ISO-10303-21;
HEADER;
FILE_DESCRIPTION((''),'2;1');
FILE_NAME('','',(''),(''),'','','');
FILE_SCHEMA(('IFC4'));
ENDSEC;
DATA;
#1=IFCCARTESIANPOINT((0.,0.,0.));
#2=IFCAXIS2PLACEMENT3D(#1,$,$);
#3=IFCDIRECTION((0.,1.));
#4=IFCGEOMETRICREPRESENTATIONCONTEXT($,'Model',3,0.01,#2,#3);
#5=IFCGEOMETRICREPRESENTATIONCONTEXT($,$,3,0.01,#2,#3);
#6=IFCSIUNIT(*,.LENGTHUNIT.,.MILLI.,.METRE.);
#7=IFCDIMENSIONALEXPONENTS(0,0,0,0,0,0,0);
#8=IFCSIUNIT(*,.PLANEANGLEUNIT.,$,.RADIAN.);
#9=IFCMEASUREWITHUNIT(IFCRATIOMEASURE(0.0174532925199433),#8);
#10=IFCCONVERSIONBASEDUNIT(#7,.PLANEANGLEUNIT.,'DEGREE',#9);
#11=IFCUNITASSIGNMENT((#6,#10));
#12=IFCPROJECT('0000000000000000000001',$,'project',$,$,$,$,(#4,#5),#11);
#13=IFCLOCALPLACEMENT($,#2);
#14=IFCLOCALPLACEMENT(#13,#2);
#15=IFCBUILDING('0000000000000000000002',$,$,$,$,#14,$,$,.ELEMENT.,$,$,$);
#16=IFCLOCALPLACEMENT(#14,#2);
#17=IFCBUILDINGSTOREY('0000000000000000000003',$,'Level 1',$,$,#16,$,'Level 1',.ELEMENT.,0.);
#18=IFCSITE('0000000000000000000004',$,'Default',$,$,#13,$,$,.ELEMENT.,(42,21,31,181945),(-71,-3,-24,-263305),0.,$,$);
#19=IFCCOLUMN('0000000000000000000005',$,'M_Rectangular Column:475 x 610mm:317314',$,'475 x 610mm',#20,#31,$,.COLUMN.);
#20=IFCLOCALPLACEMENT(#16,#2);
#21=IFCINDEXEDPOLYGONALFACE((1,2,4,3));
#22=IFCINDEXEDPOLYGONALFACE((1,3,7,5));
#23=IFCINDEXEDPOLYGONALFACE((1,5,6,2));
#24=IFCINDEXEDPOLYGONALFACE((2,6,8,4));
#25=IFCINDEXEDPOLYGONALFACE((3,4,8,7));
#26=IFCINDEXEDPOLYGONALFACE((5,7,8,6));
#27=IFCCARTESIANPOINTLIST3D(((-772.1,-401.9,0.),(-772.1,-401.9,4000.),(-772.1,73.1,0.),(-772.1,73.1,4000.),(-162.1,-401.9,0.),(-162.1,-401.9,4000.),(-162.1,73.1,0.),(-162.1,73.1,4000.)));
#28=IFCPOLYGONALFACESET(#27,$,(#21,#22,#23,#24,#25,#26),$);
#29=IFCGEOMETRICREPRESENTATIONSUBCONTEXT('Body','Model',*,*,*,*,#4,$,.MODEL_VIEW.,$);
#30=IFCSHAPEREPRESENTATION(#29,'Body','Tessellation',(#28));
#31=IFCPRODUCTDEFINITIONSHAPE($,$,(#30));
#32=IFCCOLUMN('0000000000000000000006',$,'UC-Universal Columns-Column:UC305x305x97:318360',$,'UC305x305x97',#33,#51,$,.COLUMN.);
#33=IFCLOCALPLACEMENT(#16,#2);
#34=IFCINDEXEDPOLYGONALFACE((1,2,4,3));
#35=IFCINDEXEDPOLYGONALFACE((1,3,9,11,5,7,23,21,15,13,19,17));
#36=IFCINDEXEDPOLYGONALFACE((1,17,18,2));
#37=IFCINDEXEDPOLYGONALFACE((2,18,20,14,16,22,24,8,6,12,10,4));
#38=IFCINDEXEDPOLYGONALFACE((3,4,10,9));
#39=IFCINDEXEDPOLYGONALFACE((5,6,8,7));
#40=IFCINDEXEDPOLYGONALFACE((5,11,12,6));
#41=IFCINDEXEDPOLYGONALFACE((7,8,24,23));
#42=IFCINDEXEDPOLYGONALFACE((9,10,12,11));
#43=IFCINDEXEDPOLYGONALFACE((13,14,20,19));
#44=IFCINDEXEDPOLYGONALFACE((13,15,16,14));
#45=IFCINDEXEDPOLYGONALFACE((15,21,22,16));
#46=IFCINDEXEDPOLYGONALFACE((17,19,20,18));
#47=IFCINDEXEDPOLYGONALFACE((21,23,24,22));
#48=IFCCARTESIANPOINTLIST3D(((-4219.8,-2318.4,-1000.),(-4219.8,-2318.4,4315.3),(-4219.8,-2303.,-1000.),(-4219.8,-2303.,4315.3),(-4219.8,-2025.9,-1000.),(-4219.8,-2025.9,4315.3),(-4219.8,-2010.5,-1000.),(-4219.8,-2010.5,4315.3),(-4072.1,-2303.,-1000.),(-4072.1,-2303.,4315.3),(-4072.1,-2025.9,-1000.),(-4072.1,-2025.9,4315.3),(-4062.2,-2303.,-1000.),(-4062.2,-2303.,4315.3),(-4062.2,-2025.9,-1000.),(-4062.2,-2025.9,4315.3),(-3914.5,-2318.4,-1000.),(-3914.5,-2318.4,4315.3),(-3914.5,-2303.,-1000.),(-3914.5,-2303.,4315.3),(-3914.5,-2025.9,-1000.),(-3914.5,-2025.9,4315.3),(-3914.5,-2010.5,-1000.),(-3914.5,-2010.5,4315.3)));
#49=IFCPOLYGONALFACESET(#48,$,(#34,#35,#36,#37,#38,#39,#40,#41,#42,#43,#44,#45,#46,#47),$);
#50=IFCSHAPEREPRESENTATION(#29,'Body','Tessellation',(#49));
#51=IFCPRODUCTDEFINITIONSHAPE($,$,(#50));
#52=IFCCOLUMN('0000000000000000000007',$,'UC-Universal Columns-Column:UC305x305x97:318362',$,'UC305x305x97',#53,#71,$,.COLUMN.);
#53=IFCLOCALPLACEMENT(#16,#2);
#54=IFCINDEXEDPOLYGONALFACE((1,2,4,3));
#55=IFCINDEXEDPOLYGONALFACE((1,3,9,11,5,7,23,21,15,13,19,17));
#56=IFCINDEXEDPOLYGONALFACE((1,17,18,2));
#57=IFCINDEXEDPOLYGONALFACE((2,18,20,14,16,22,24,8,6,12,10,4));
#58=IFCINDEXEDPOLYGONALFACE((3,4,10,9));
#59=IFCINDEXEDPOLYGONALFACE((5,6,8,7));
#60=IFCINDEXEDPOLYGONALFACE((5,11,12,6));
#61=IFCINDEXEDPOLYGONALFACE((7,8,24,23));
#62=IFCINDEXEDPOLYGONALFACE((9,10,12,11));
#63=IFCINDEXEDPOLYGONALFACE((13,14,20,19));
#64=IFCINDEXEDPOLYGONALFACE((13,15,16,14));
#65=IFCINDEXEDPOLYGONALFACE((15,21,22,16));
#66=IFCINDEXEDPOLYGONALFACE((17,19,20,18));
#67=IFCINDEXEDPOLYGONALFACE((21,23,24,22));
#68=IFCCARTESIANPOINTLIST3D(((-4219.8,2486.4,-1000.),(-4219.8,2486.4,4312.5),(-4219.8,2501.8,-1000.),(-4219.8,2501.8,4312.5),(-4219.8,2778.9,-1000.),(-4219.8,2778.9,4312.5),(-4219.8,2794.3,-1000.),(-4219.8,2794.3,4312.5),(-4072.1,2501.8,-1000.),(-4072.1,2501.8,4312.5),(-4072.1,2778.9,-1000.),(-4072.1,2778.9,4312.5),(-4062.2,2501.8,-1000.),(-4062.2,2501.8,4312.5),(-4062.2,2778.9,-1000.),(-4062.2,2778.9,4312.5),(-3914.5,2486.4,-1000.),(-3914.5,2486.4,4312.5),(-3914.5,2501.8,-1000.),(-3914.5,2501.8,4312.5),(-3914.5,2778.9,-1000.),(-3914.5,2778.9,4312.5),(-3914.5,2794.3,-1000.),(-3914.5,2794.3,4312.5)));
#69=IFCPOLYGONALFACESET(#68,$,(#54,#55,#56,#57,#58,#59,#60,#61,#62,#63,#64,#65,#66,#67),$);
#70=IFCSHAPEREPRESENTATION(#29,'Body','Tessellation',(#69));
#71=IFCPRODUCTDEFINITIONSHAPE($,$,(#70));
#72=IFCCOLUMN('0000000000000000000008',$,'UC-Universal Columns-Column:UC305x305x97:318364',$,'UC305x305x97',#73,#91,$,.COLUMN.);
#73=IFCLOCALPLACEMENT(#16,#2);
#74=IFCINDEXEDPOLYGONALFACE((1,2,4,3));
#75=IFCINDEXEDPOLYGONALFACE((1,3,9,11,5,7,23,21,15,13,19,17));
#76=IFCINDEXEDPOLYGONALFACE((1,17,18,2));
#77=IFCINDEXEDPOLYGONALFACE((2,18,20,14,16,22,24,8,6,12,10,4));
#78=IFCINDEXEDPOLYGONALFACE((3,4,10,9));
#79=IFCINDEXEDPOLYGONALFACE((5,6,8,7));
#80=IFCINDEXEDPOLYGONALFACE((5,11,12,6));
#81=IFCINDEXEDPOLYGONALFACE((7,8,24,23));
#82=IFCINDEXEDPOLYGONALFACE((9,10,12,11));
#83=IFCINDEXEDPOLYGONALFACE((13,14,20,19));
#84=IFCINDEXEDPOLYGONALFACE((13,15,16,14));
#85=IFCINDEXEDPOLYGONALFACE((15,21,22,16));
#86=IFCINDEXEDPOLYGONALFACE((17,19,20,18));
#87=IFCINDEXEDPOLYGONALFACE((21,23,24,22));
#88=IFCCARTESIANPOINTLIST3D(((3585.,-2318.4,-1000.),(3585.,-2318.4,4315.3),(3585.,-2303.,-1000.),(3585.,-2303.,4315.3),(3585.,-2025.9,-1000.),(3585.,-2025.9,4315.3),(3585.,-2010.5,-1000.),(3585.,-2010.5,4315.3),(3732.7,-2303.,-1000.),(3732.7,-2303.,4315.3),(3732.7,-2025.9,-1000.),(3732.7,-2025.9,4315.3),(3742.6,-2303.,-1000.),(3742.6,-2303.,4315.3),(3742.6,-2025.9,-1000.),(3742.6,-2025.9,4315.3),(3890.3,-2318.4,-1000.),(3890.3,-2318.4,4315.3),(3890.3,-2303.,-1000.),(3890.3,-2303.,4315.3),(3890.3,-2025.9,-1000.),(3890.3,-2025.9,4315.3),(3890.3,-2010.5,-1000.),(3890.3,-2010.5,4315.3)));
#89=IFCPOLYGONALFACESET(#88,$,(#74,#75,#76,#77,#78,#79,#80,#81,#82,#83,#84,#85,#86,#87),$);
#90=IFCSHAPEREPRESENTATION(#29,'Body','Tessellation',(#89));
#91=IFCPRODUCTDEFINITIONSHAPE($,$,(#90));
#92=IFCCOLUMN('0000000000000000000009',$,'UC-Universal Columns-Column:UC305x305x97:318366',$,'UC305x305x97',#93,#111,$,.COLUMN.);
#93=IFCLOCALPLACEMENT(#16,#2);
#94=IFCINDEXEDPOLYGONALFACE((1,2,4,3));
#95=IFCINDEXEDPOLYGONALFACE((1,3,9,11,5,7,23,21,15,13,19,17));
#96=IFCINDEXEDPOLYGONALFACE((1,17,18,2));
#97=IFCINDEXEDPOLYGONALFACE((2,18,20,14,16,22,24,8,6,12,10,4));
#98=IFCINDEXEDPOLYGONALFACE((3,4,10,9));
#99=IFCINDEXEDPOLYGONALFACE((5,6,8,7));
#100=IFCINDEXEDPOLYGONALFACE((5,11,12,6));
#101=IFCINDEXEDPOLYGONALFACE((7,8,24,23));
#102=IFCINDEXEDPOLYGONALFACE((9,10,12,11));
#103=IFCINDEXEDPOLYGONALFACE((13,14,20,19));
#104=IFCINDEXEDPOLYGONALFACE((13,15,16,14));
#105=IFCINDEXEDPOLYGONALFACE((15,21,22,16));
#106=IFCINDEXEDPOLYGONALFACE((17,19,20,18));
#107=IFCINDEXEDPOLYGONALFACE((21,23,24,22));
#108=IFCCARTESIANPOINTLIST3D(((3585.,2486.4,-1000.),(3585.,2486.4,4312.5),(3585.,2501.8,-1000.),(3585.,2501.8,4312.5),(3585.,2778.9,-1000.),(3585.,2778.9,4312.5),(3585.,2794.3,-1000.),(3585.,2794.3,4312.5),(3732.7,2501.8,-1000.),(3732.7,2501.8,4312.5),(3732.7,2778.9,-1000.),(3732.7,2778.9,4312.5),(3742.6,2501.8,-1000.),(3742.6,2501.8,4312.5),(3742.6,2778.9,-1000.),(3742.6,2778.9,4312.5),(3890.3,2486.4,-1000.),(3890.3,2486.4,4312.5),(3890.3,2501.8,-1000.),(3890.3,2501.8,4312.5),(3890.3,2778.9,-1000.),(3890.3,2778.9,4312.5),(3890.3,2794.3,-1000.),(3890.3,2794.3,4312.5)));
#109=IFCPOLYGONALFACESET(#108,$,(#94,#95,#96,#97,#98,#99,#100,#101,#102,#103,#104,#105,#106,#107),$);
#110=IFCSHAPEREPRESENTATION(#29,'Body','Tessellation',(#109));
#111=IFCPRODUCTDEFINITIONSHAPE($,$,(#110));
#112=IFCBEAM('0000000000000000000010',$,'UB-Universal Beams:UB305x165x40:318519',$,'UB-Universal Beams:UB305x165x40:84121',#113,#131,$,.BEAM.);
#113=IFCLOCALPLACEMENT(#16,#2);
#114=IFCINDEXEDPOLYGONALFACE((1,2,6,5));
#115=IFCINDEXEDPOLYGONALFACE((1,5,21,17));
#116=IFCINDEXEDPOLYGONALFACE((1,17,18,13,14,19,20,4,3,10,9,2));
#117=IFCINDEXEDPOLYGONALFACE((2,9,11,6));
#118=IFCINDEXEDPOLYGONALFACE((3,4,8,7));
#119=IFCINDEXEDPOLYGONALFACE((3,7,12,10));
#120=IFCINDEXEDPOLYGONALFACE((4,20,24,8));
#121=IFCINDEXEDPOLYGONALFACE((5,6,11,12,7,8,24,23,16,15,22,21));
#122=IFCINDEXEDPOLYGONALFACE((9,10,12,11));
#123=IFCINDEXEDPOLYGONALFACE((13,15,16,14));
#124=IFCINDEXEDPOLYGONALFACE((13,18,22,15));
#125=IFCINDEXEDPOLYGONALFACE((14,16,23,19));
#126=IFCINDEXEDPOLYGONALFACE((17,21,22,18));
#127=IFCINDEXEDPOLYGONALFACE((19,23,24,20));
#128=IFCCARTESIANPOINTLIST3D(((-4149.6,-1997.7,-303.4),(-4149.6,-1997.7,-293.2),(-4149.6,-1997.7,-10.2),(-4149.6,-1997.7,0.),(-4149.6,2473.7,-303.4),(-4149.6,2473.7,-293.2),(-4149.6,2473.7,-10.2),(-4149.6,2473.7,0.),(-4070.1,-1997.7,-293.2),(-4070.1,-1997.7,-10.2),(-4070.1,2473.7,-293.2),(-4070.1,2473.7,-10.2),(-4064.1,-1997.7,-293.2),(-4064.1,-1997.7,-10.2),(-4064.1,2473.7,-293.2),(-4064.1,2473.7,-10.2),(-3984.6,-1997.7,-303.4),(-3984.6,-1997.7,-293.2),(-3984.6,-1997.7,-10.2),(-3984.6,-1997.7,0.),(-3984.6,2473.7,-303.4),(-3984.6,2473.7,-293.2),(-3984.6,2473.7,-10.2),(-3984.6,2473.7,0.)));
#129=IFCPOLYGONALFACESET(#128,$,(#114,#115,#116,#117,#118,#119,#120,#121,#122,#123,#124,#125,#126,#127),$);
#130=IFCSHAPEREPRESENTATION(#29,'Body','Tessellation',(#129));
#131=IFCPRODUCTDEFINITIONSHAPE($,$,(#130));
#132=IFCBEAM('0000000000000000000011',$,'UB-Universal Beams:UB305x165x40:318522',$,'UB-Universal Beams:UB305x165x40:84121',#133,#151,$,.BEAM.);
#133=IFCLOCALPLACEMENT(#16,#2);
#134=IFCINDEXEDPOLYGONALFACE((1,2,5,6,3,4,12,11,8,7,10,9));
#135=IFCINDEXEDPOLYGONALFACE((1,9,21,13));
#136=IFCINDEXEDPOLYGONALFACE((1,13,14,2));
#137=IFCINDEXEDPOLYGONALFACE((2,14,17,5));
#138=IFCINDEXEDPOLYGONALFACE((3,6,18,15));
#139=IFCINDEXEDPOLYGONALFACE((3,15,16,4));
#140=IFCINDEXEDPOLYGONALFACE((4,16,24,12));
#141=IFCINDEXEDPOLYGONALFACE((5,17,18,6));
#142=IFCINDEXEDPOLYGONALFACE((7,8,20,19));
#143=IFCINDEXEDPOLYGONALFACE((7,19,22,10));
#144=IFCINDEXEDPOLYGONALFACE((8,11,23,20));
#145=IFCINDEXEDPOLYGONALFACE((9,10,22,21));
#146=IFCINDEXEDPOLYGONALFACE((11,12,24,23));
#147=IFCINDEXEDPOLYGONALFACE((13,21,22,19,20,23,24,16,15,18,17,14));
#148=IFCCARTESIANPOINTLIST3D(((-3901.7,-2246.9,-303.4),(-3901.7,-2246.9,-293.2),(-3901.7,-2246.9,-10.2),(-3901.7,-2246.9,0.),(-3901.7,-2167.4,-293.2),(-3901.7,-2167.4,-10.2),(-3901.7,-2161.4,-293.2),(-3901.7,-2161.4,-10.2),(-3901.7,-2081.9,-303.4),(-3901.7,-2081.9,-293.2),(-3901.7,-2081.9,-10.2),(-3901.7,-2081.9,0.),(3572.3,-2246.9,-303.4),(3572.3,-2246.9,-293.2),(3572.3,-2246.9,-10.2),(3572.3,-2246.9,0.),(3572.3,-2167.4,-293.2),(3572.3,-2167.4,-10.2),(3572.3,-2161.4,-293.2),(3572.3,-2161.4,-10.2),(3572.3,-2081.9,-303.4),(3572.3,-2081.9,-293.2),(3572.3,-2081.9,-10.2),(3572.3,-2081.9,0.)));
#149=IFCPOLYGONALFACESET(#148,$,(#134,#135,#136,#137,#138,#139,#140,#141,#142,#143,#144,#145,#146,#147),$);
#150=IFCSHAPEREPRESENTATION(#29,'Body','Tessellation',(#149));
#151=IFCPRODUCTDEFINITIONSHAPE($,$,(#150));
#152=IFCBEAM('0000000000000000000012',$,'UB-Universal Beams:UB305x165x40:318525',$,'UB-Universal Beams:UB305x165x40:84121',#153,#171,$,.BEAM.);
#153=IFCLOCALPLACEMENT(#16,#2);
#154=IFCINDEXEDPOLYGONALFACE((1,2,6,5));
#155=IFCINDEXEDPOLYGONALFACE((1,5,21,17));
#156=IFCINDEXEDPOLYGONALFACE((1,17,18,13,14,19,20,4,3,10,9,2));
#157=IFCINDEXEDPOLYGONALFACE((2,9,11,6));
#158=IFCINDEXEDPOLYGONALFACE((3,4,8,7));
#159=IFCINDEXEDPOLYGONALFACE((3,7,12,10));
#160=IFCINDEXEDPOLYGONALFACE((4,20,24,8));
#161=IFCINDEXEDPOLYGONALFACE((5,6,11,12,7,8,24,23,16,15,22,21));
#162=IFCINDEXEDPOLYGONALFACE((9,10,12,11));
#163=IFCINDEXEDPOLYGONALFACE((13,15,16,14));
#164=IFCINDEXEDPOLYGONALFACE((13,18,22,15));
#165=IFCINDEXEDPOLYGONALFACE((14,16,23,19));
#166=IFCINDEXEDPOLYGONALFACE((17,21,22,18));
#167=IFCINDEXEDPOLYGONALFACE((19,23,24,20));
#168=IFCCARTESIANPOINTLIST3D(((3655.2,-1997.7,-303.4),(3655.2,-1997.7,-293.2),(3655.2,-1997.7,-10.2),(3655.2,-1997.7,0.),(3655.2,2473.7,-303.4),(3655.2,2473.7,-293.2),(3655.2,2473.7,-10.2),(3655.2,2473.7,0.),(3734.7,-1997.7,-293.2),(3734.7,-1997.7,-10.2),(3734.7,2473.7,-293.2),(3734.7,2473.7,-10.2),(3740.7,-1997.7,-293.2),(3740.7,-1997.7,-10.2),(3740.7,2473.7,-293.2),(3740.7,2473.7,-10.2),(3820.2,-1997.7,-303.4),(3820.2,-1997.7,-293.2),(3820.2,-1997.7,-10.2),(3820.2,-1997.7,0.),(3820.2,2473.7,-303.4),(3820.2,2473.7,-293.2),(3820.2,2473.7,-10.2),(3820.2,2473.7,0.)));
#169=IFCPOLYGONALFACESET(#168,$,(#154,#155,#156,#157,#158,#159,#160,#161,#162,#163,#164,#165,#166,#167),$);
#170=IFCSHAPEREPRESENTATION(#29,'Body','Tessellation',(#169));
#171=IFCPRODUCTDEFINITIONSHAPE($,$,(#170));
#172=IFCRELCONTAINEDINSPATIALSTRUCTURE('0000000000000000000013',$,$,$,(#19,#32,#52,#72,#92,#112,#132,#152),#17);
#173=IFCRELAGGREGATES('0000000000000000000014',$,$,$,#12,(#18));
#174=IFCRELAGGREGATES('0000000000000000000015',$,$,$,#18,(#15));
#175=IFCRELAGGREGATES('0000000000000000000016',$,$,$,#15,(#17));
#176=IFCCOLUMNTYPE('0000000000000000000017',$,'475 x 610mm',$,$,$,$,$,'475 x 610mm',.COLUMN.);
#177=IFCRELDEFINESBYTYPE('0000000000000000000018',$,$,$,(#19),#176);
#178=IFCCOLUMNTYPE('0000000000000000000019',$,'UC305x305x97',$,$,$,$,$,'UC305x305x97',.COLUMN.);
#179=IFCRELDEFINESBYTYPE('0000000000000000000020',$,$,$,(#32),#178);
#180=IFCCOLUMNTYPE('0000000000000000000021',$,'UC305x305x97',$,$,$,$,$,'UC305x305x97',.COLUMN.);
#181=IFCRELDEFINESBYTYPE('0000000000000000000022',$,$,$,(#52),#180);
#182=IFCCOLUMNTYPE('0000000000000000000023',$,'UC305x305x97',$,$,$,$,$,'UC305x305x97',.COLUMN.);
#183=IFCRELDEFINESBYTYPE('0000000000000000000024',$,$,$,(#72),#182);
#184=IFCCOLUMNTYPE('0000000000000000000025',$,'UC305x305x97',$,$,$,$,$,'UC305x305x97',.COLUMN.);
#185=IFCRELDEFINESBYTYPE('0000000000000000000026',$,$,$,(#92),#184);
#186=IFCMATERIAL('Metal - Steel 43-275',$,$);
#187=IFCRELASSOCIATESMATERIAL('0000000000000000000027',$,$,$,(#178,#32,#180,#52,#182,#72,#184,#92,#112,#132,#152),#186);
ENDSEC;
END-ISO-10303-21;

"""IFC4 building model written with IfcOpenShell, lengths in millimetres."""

from ifc_helpers import new_model, entity, si_unit, converted_unit, direction, frame, frame_2d, origin, origin_2d_with_axis, place, context, subcontext, project, spatial, rectangle, i_section, extrude, source, transform, mapped, material, type_object, type_shapes, element, save


model = new_model("IFC4")

# Units and contexts
model_context = context("Model", 3, precision=0.01, world=origin(), true_north=direction((0.0, 1.0)))
context_of_model = context(None, 3, precision=0.01, world=origin(), true_north=direction((0.0, 1.0)))
body_context = subcontext(model_context, "Body", "Model", "MODEL_VIEW")
ifc_project = project(units=[si_unit("LENGTHUNIT", "METRE", prefix="MILLI"), converted_unit("PLANEANGLEUNIT", "DEGREE", entity("IfcRatioMeasure", 0.0174532925199433), si_unit("PLANEANGLEUNIT", "RADIAN"), dimensions=[0, 0, 0, 0, 0, 0, 0])], contexts=[model_context, context_of_model])

# Site, building, storey
site_placement = place(None, origin())
site = spatial("IfcSite", under=ifc_project, at=site_placement, Name="Default", CompositionType="ELEMENT", RefLatitude=(42, 21, 31, 181945), RefLongitude=(-71, -3, -24, -263305), RefElevation=0.0)
building_placement = place(site_placement, origin())
building = spatial("IfcBuilding", under=site, at=building_placement, CompositionType="ELEMENT")
storey_placement = place(building_placement, origin())
storey = spatial("IfcBuildingStorey", under=building, at=storey_placement, Name="Level 1", LongName="Level 1", CompositionType="ELEMENT", Elevation=0.0)

# Columns
column_type_1 = type_object("IfcColumnType", Name="475 x 610mm", ElementType="475 x 610mm", PredefinedType="COLUMN")
shared_shape_1 = source(origin(), body_context, "Body", "SweptSolid", [
    extrude(rectangle(XDim=475.0, YDim=610.0, at=origin_2d_with_axis()), frame((0.0, 0.0, 0.0), z_axis=(0.0, 0.0, 1.0), x_axis=(0.0, -1.0, 0.0)), (0.0, 0.0, 1.0), 4000.0),
])
type_shapes(column_type_1, [shared_shape_1])
column_1_placement = place(storey_placement, frame((-467.1, -164.4, 0.0)))
element("IfcColumn", 1, at=column_1_placement, inside=storey, type_object=column_type_1, Name="M_Rectangular Column:475 x 610mm:317314", ObjectType="475 x 610mm", PredefinedType="COLUMN", context=body_context, shape_type="MappedRepresentation", body=[
    mapped(shared_shape_1, transform((0.0, 0.0, 0.0), scale=1.0)),
])
ifc_material_1 = material(Name="Metal - Steel 43-275")
column_type_2 = type_object("IfcColumnType", Name="UC305x305x97", ElementType="UC305x305x97", PredefinedType="COLUMN", material=ifc_material_1)
shared_shape_2 = source(origin(), body_context, "Body", "SweptSolid", [
    extrude(i_section(OverallWidth=305.3, OverallDepth=307.9, WebThickness=9.9, FlangeThickness=15.4, at=frame_2d((0.0, 0.0), x_axis=(0.0, 1.0))), frame((-4067.1, -2164.4, -1000.0), z_axis=(0.0, 0.0, 1.0), x_axis=(0.0, -1.0, 0.0)), (0.0, 0.0, 1.0), 5315.3),
])
type_shapes(column_type_2, [shared_shape_2])
column_2_placement = place(storey_placement, origin())
element("IfcColumn", 2, at=column_2_placement, inside=storey, type_object=column_type_2, material=ifc_material_1, Name="UC-Universal Columns-Column:UC305x305x97:318360", ObjectType="UC305x305x97", PredefinedType="COLUMN", context=body_context, shape_type="MappedRepresentation", body=[
    mapped(shared_shape_2, transform((0.0, 0.0, 0.0), scale=1.0)),
])
column_type_3 = type_object("IfcColumnType", Name="UC305x305x97", ElementType="UC305x305x97", PredefinedType="COLUMN", material=ifc_material_1)
shared_shape_3 = source(origin(), body_context, "Body", "SweptSolid", [
    extrude(i_section(OverallWidth=305.3, OverallDepth=307.9, WebThickness=9.9, FlangeThickness=15.4, at=frame_2d((0.0, 0.0), x_axis=(0.0, 1.0))), frame((-4067.1, 2640.4, -1000.0), z_axis=(0.0, 0.0, 1.0), x_axis=(0.0, -1.0, 0.0)), (0.0, 0.0, 1.0), 5312.5),
])
type_shapes(column_type_3, [shared_shape_3])
column_3_placement = place(storey_placement, origin())
element("IfcColumn", 3, at=column_3_placement, inside=storey, type_object=column_type_3, material=ifc_material_1, Name="UC-Universal Columns-Column:UC305x305x97:318362", ObjectType="UC305x305x97", PredefinedType="COLUMN", context=body_context, shape_type="MappedRepresentation", body=[
    mapped(shared_shape_3, transform((0.0, 0.0, 0.0), scale=1.0)),
])
column_type_4 = type_object("IfcColumnType", Name="UC305x305x97", ElementType="UC305x305x97", PredefinedType="COLUMN", material=ifc_material_1)
shared_shape_4 = source(origin(), body_context, "Body", "SweptSolid", [
    extrude(i_section(OverallWidth=305.3, OverallDepth=307.9, WebThickness=9.9, FlangeThickness=15.4, at=frame_2d((0.0, 0.0), x_axis=(0.0, 1.0))), frame((3737.7, -2164.4, -1000.0), z_axis=(0.0, 0.0, 1.0), x_axis=(0.0, -1.0, 0.0)), (0.0, 0.0, 1.0), 5315.3),
])
type_shapes(column_type_4, [shared_shape_4])
column_4_placement = place(storey_placement, origin())
element("IfcColumn", 4, at=column_4_placement, inside=storey, type_object=column_type_4, material=ifc_material_1, Name="UC-Universal Columns-Column:UC305x305x97:318364", ObjectType="UC305x305x97", PredefinedType="COLUMN", context=body_context, shape_type="MappedRepresentation", body=[
    mapped(shared_shape_4, transform((0.0, 0.0, 0.0), scale=1.0)),
])
column_type_5 = type_object("IfcColumnType", Name="UC305x305x97", ElementType="UC305x305x97", PredefinedType="COLUMN", material=ifc_material_1)
shared_shape_5 = source(origin(), body_context, "Body", "SweptSolid", [
    extrude(i_section(OverallWidth=305.3, OverallDepth=307.9, WebThickness=9.9, FlangeThickness=15.4, at=frame_2d((0.0, 0.0), x_axis=(0.0, 1.0))), frame((3737.7, 2640.4, -1000.0), z_axis=(0.0, 0.0, 1.0), x_axis=(0.0, -1.0, 0.0)), (0.0, 0.0, 1.0), 5312.5),
])
type_shapes(column_type_5, [shared_shape_5])
column_5_placement = place(storey_placement, origin())
element("IfcColumn", 5, at=column_5_placement, inside=storey, type_object=column_type_5, material=ifc_material_1, Name="UC-Universal Columns-Column:UC305x305x97:318366", ObjectType="UC305x305x97", PredefinedType="COLUMN", context=body_context, shape_type="MappedRepresentation", body=[
    mapped(shared_shape_5, transform((0.0, 0.0, 0.0), scale=1.0)),
])

# Beams
beam_1_placement = place(storey_placement, frame((-4067.1, 2640.4, 0.0), z_axis=(0.0, 0.0, 1.0), x_axis=(0.0, -1.0, 0.0)))
element("IfcBeam", 6, at=beam_1_placement, inside=storey, material=ifc_material_1, Name="UB-Universal Beams:UB305x165x40:318519", ObjectType="UB-Universal Beams:UB305x165x40:84121", PredefinedType="BEAM", context=body_context, shape_type="SweptSolid", body=[
    extrude(i_section(OverallWidth=165.0, OverallDepth=303.4, WebThickness=6.0, FlangeThickness=10.2, at=frame_2d((0.0, 0.0), x_axis=(0.0, 1.0))), frame((166.7, 0.0, -151.7), z_axis=(1.0, 0.0, 0.0), x_axis=(0.0, 0.0, -1.0)), (0.0, 0.0, 1.0), 4471.4),
])
beam_2_placement = place(storey_placement, frame((-4067.1, -2164.4, 0.0)))
element("IfcBeam", 7, at=beam_2_placement, inside=storey, material=ifc_material_1, Name="UB-Universal Beams:UB305x165x40:318522", ObjectType="UB-Universal Beams:UB305x165x40:84121", PredefinedType="BEAM", context=body_context, shape_type="SweptSolid", body=[
    extrude(i_section(OverallWidth=165.0, OverallDepth=303.4, WebThickness=6.0, FlangeThickness=10.2, at=frame_2d((0.0, 0.0), x_axis=(0.0, 1.0))), frame((165.4, 0.0, -151.7), z_axis=(1.0, 0.0, 0.0), x_axis=(0.0, 0.0, -1.0)), (0.0, 0.0, 1.0), 7474.0),
])
beam_3_placement = place(storey_placement, frame((3737.7, 2640.4, 0.0), z_axis=(0.0, 0.0, 1.0), x_axis=(0.0, -1.0, 0.0)))
element("IfcBeam", 8, at=beam_3_placement, inside=storey, material=ifc_material_1, Name="UB-Universal Beams:UB305x165x40:318525", ObjectType="UB-Universal Beams:UB305x165x40:84121", PredefinedType="BEAM", context=body_context, shape_type="SweptSolid", body=[
    extrude(i_section(OverallWidth=165.0, OverallDepth=303.4, WebThickness=6.0, FlangeThickness=10.2, at=frame_2d((0.0, 0.0), x_axis=(0.0, 1.0))), frame((166.7, 0.0, -151.7), z_axis=(1.0, 0.0, 0.0), x_axis=(0.0, 0.0, -1.0)), (0.0, 0.0, 1.0), 4471.4),
])

save(model, "model.ifc")
